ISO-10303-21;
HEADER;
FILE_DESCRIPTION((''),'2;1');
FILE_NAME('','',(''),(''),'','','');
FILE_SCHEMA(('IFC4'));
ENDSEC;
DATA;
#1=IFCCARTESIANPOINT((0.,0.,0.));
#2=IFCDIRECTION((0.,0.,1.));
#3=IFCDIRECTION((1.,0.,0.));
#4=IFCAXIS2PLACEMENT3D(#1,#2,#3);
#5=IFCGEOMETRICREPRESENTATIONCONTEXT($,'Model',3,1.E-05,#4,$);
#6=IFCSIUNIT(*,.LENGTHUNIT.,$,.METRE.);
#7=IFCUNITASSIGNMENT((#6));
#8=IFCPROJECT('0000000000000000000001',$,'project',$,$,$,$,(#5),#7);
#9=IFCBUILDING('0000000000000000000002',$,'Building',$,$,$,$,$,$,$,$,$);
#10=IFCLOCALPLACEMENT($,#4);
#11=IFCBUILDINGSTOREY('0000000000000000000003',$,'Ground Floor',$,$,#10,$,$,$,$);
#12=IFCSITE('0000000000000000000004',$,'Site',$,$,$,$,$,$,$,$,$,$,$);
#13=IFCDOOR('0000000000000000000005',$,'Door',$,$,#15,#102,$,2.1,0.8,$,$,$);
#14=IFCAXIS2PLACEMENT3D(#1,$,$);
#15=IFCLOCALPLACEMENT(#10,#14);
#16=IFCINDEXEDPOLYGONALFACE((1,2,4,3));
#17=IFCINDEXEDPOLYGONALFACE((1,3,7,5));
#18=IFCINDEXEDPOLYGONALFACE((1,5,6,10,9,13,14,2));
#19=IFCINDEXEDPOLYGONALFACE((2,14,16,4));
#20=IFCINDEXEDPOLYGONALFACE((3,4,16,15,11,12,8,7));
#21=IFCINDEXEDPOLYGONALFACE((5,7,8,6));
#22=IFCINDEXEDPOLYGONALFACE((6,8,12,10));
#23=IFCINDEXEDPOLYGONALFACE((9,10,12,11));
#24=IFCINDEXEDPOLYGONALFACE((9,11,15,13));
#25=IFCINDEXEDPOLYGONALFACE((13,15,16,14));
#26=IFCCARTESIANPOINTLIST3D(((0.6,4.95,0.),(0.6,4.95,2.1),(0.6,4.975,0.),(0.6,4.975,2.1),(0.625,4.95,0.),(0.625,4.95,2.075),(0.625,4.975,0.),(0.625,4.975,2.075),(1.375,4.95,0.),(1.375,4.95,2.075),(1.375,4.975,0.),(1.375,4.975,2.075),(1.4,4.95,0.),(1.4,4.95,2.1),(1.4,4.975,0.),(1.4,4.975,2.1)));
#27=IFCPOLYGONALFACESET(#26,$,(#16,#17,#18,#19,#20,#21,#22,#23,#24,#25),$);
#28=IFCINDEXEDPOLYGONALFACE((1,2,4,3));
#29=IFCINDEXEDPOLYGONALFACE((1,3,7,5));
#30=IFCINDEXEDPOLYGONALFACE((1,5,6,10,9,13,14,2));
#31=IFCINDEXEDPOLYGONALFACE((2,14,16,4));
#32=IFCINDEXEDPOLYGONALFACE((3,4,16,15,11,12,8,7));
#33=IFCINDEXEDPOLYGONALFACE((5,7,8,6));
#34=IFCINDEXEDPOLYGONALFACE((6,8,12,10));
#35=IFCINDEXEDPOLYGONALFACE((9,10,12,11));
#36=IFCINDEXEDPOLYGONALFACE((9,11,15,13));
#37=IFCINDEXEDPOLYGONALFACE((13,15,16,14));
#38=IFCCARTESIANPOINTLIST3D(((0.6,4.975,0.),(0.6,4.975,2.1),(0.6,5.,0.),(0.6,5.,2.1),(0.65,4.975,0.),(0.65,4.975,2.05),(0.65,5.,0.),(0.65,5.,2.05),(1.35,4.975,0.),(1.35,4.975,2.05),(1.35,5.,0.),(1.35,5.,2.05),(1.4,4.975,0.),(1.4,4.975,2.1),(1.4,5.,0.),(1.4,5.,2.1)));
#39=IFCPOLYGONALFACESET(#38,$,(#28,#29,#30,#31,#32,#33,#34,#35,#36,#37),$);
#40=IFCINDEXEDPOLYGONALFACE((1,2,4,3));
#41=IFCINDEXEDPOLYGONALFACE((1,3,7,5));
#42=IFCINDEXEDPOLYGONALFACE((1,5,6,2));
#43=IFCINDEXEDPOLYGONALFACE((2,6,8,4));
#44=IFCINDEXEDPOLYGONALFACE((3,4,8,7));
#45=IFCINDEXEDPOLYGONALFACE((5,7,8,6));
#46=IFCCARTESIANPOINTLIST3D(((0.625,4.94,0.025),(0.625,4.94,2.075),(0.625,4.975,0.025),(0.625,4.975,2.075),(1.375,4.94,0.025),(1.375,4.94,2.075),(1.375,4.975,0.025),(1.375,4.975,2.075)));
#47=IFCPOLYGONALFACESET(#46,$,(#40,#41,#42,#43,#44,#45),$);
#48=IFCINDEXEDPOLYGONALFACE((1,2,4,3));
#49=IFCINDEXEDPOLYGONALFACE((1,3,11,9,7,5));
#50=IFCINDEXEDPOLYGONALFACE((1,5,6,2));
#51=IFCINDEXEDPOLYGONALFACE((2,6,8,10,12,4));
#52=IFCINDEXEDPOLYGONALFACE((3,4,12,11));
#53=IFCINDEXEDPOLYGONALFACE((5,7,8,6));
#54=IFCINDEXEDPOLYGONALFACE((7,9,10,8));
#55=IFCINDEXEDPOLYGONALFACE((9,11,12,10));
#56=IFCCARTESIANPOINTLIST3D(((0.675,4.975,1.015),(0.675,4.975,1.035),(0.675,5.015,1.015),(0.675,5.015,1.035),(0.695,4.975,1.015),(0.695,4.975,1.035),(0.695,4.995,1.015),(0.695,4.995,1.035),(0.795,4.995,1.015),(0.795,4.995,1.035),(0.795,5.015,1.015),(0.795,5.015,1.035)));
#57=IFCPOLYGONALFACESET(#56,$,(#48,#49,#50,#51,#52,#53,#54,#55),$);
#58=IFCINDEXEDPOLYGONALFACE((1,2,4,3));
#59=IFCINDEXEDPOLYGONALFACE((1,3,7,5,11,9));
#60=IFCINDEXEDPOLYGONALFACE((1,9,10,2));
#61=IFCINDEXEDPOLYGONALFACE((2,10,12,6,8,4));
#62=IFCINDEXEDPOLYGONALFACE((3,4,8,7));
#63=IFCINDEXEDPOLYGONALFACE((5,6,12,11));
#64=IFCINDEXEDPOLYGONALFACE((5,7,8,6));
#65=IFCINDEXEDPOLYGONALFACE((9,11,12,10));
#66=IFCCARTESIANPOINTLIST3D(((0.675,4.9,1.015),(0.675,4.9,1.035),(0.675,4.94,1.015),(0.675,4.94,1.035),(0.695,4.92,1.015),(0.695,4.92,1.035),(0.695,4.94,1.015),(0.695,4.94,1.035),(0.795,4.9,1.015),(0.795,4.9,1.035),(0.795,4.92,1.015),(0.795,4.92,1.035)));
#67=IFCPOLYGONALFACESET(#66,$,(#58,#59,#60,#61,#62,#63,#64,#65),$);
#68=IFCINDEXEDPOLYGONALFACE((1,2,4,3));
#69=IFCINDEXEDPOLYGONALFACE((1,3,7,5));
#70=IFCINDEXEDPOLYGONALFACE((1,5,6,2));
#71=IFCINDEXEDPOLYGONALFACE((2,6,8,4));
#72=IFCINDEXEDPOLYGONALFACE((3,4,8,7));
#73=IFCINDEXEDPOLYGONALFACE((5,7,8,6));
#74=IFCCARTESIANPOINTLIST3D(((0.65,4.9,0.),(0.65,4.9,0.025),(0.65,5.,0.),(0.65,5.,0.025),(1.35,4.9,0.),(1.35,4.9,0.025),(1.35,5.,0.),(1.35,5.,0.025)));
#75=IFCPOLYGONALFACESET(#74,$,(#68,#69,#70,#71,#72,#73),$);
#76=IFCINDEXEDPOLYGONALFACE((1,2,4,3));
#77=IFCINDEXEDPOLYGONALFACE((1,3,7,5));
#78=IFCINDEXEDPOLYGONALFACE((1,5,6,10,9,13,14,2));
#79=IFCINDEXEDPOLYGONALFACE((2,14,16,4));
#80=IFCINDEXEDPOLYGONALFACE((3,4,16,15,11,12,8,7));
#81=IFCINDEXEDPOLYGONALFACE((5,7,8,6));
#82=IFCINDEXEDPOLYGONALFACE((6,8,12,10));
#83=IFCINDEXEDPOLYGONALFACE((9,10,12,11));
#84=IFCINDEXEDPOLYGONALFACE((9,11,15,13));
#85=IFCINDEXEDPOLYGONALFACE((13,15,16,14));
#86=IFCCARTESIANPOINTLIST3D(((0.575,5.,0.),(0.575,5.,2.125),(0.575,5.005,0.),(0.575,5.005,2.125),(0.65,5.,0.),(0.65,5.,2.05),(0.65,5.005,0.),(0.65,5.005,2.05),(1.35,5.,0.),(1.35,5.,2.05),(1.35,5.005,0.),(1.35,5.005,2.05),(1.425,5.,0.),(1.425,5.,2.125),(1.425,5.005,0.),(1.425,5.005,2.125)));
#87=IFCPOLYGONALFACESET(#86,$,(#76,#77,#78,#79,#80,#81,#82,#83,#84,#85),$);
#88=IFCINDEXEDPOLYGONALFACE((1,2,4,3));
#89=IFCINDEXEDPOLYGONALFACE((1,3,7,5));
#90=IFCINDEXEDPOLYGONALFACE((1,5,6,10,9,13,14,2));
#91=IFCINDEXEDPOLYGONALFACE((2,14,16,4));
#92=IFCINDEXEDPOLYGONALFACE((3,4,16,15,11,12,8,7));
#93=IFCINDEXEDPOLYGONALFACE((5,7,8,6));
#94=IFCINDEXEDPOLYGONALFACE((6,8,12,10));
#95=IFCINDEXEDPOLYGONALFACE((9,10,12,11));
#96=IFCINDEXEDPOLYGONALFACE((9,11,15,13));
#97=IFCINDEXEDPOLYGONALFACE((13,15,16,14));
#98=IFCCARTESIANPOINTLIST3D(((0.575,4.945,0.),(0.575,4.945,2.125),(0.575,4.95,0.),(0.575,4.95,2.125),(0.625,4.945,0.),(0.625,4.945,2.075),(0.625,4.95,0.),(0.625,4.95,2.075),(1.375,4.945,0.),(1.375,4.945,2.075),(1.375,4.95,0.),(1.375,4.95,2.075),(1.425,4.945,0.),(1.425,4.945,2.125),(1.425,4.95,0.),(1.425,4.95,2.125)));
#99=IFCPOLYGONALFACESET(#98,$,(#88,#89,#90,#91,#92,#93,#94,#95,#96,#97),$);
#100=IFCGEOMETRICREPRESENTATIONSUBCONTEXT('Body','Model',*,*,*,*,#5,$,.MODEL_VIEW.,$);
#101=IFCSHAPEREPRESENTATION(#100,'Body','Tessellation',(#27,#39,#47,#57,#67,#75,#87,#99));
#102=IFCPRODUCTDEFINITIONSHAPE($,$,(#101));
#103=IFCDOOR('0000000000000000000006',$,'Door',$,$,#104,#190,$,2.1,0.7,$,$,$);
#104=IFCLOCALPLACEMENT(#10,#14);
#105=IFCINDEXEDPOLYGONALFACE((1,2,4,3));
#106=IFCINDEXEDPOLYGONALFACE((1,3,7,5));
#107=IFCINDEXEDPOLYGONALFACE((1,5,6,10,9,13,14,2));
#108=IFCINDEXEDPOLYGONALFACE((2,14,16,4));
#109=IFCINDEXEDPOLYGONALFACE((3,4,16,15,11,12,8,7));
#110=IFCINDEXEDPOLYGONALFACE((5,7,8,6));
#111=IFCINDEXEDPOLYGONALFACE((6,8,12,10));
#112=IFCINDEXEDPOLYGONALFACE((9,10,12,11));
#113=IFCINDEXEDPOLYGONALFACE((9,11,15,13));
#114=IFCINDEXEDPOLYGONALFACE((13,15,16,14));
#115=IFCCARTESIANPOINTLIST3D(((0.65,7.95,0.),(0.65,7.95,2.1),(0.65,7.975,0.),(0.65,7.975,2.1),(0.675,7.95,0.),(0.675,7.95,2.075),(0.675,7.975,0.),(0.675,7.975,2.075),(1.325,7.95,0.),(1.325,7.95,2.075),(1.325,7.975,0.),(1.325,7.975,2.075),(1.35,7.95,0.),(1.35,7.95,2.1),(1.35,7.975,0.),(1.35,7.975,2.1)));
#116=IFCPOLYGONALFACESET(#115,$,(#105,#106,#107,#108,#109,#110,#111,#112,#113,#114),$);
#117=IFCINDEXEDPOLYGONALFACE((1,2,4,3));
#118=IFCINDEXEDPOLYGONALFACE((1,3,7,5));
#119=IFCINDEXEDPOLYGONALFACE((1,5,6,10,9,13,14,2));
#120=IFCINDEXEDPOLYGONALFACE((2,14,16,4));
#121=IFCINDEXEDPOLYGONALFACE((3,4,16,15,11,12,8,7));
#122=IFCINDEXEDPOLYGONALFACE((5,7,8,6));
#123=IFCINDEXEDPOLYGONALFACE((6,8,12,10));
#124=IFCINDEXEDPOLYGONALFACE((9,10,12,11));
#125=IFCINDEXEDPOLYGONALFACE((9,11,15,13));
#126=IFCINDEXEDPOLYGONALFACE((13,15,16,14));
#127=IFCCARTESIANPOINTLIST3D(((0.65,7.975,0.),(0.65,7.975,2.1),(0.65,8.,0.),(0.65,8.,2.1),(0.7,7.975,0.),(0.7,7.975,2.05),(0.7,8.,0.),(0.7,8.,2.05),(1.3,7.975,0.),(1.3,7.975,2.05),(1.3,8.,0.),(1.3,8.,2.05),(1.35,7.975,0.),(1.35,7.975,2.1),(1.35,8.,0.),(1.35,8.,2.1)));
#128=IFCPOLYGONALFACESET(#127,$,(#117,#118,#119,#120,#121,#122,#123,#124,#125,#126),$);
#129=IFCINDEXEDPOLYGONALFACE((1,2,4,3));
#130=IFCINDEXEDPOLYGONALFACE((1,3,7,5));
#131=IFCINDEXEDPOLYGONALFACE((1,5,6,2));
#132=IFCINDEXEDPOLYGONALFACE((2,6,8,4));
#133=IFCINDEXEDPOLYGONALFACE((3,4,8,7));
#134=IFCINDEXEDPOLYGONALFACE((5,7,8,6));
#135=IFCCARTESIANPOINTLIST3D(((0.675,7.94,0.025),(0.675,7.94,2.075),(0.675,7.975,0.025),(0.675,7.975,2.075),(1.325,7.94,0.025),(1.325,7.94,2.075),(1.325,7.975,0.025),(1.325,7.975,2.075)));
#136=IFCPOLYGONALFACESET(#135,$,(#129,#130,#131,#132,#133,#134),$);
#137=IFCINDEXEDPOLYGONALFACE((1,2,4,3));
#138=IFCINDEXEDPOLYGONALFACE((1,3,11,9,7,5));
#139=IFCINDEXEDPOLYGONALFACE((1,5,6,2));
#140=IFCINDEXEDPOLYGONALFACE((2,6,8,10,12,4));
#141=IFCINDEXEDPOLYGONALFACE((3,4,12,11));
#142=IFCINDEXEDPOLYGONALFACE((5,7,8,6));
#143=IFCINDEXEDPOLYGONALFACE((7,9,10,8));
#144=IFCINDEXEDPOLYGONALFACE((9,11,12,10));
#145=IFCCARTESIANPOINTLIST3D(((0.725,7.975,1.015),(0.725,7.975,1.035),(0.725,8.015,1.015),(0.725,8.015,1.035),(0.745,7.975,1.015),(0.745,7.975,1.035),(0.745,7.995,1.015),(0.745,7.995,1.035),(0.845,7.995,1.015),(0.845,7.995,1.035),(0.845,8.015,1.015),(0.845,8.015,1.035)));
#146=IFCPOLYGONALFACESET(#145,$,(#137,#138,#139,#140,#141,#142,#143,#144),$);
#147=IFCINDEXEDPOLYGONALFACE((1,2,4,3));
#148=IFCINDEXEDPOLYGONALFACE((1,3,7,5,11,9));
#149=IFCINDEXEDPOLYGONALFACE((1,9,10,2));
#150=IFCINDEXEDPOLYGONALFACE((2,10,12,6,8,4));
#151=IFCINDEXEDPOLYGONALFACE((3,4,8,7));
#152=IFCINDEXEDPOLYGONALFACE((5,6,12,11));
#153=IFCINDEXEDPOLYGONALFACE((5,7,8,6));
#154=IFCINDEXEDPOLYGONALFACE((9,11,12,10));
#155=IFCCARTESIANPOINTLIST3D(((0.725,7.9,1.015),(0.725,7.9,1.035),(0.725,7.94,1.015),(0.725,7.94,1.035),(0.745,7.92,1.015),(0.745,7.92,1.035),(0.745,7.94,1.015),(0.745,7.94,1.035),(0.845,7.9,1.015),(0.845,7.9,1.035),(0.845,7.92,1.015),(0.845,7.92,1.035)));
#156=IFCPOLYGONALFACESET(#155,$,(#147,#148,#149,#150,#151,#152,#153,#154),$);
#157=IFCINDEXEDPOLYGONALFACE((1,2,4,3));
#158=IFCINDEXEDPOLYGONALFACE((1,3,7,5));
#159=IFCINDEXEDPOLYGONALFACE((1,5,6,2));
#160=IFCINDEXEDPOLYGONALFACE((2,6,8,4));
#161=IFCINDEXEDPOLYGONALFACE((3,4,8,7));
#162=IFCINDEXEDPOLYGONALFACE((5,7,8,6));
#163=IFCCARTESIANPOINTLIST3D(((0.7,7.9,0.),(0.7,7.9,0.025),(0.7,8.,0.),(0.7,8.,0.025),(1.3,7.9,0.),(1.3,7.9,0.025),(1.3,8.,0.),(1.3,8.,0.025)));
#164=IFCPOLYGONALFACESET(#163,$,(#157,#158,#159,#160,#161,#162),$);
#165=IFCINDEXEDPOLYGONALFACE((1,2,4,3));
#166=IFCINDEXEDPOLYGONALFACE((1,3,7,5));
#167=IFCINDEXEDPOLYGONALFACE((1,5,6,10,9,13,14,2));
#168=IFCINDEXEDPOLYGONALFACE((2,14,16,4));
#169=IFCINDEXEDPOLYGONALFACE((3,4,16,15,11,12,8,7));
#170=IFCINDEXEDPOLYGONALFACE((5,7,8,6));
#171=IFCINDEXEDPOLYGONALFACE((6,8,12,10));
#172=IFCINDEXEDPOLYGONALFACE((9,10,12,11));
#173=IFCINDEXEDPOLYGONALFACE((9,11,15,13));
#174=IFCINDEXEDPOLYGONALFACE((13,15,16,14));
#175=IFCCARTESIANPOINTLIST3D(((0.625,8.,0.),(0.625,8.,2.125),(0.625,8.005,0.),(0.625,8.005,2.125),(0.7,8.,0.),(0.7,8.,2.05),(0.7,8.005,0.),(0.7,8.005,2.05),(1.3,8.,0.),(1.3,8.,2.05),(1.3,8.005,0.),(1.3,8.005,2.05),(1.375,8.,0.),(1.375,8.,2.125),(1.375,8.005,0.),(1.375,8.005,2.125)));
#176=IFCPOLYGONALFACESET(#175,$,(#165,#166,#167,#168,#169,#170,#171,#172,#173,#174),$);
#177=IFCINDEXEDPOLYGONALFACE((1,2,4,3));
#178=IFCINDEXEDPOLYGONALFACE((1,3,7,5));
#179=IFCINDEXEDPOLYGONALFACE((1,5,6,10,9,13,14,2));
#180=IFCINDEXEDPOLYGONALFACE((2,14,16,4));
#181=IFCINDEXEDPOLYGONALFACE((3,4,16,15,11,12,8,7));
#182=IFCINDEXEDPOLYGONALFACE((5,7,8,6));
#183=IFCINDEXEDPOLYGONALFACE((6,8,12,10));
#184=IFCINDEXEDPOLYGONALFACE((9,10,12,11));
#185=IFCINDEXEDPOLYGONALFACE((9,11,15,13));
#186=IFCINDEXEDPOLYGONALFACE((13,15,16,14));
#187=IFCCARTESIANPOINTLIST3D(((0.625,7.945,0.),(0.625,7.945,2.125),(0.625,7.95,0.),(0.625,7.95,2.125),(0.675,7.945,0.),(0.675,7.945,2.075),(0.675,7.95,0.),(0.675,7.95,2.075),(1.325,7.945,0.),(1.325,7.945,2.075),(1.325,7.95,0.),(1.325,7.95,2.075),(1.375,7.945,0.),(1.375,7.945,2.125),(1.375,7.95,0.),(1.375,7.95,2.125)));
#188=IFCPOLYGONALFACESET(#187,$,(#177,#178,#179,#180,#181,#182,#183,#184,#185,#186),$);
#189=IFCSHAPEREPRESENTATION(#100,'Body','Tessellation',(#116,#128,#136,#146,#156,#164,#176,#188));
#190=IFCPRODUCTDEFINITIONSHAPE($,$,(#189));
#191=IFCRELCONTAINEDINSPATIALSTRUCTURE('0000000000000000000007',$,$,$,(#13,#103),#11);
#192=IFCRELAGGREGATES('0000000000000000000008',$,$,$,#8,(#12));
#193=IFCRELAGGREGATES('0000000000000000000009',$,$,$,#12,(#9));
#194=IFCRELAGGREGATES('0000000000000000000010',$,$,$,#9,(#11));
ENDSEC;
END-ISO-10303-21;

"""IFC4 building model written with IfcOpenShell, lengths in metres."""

from ifc_helpers import new_model, si_unit, frame, origin_with_axes, place, context, subcontext, project, spatial, line, indexed_curve, outline, extrude, element, save


model = new_model("IFC4")

# Units and contexts
model_context = context("Model", 3, precision=1e-05, world=origin_with_axes())
body_context = subcontext(model_context, "Body", "Model", "MODEL_VIEW")
ifc_project = project(units=[si_unit("LENGTHUNIT", "METRE")], contexts=[model_context])

# Site, building, storey
site = spatial("IfcSite", under=ifc_project, Name="Site")
building = spatial("IfcBuilding", under=site, Name="Building")
storey_placement = place(None, origin_with_axes())
storey = spatial("IfcBuildingStorey", under=building, at=storey_placement, Name="Ground Floor")

# Doors
door_1_placement = place(storey_placement, frame((1.4, 5.0, 0.0), z_axis=(0.0, 0.0, 1.0), x_axis=(-1.0, 0.0, 0.0)))
element("IfcDoor", 1, at=door_1_placement, inside=storey, Name="Door", OverallHeight=2.1, OverallWidth=0.8, context=body_context, shape_type="SweptSolid", body=[
    extrude(outline(indexed_curve([(0.0, 0.0), (0.0, 2.1), (0.8, 2.1), (0.8, 0.0), (0.775, 0.0), (0.775, 2.075), (0.025, 2.075), (0.025, 0.0)], segments=[line(1, 2, 3, 4, 5, 6, 7, 8, 1)])), frame((0.0, 0.025, 0.0), z_axis=(0.0, -1.0, 0.0), x_axis=(1.0, 0.0, 0.0)), (0.0, 0.0, -1.0), 0.025),
    extrude(outline(indexed_curve([(0.0, 0.0), (0.0, 2.1), (0.8, 2.1), (0.8, 0.0), (0.75, 0.0), (0.75, 2.05), (0.05, 2.05), (0.05, 0.0)], segments=[line(1, 2, 3, 4, 5, 6, 7, 8, 1)])), frame((0.0, 0.0, 0.0), z_axis=(0.0, -1.0, 0.0), x_axis=(1.0, 0.0, 0.0)), (0.0, 0.0, -1.0), 0.025),
    extrude(outline(indexed_curve([(0.0, 0.0), (0.75, 0.0), (0.75, 0.035), (0.0, 0.035)], segments=[line(1, 2, 3, 4, 1)])), frame((0.025, 0.025, 0.025), z_axis=(0.0, 0.0, 1.0), x_axis=(1.0, 0.0, 0.0)), (0.0, 0.0, 1.0), 2.05),
    extrude(outline(indexed_curve([(0.0, 0.0), (0.0, -0.04), (-0.12, -0.04), (-0.12, -0.02), (-0.02, -0.02), (-0.02, 0.0)], segments=[line(1, 2, 3, 4, 5, 6, 1)])), frame((0.725, 0.025, 1.015), z_axis=(0.0, 0.0, 1.0), x_axis=(1.0, 0.0, 0.0)), (0.0, 0.0, 1.0), 0.02),
    extrude(outline(indexed_curve([(0.0, 0.0), (0.0, 0.04), (-0.12, 0.04), (-0.12, 0.02), (-0.02, 0.02), (-0.02, 0.0)], segments=[line(1, 2, 3, 4, 5, 6, 1)])), frame((0.725, 0.06, 1.015), z_axis=(0.0, 0.0, 1.0), x_axis=(1.0, 0.0, 0.0)), (0.0, 0.0, 1.0), 0.02),
    extrude(outline(indexed_curve([(0.0, 0.0), (0.7, 0.0), (0.7, 0.1), (0.0, 0.1)], segments=[line(1, 2, 3, 4, 1)])), frame((0.05, 0.0, 0.0), z_axis=(0.0, 0.0, 1.0), x_axis=(1.0, 0.0, 0.0)), (0.0, 0.0, 1.0), 0.025),
    extrude(outline(indexed_curve([(0.0, 0.0), (0.0, 2.125), (0.85, 2.125), (0.85, 0.0), (0.775, 0.0), (0.775, 2.05), (0.075, 2.05), (0.075, 0.0)], segments=[line(1, 2, 3, 4, 5, 6, 7, 8, 1)])), frame((-0.025, -0.005, 0.0), z_axis=(0.0, -1.0, 0.0), x_axis=(1.0, 0.0, 0.0)), (0.0, 0.0, -1.0), 0.005),
    extrude(outline(indexed_curve([(0.0, 0.0), (0.0, 2.125), (0.85, 2.125), (0.85, 0.0), (0.8, 0.0), (0.8, 2.075), (0.05, 2.075), (0.05, 0.0)], segments=[line(1, 2, 3, 4, 5, 6, 7, 8, 1)])), frame((-0.025, 0.05, 0.0), z_axis=(0.0, -1.0, 0.0), x_axis=(1.0, 0.0, 0.0)), (0.0, 0.0, -1.0), 0.005),
])
door_2_placement = place(storey_placement, frame((1.35, 8.0, 0.0), z_axis=(0.0, 0.0, 1.0), x_axis=(-1.0, 0.0, 0.0)))
element("IfcDoor", 2, at=door_2_placement, inside=storey, Name="Door", OverallHeight=2.1, OverallWidth=0.7, context=body_context, shape_type="SweptSolid", body=[
    extrude(outline(indexed_curve([(0.0, 0.0), (0.0, 2.1), (0.7, 2.1), (0.7, 0.0), (0.675, 0.0), (0.675, 2.075), (0.025, 2.075), (0.025, 0.0)], segments=[line(1, 2, 3, 4, 5, 6, 7, 8, 1)])), frame((0.0, 0.025, 0.0), z_axis=(0.0, -1.0, 0.0), x_axis=(1.0, 0.0, 0.0)), (0.0, 0.0, -1.0), 0.025),
    extrude(outline(indexed_curve([(0.0, 0.0), (0.0, 2.1), (0.7, 2.1), (0.7, 0.0), (0.65, 0.0), (0.65, 2.05), (0.05, 2.05), (0.05, 0.0)], segments=[line(1, 2, 3, 4, 5, 6, 7, 8, 1)])), frame((0.0, 0.0, 0.0), z_axis=(0.0, -1.0, 0.0), x_axis=(1.0, 0.0, 0.0)), (0.0, 0.0, -1.0), 0.025),
    extrude(outline(indexed_curve([(0.0, 0.0), (0.65, 0.0), (0.65, 0.035), (0.0, 0.035)], segments=[line(1, 2, 3, 4, 1)])), frame((0.025, 0.025, 0.025), z_axis=(0.0, 0.0, 1.0), x_axis=(1.0, 0.0, 0.0)), (0.0, 0.0, 1.0), 2.05),
    extrude(outline(indexed_curve([(0.0, 0.0), (0.0, -0.04), (-0.12, -0.04), (-0.12, -0.02), (-0.02, -0.02), (-0.02, 0.0)], segments=[line(1, 2, 3, 4, 5, 6, 1)])), frame((0.625, 0.025, 1.015), z_axis=(0.0, 0.0, 1.0), x_axis=(1.0, 0.0, 0.0)), (0.0, 0.0, 1.0), 0.02),
    extrude(outline(indexed_curve([(0.0, 0.0), (0.0, 0.04), (-0.12, 0.04), (-0.12, 0.02), (-0.02, 0.02), (-0.02, 0.0)], segments=[line(1, 2, 3, 4, 5, 6, 1)])), frame((0.625, 0.06, 1.015), z_axis=(0.0, 0.0, 1.0), x_axis=(1.0, 0.0, 0.0)), (0.0, 0.0, 1.0), 0.02),
    extrude(outline(indexed_curve([(0.0, 0.0), (0.6, 0.0), (0.6, 0.1), (0.0, 0.1)], segments=[line(1, 2, 3, 4, 1)])), frame((0.05, 0.0, 0.0), z_axis=(0.0, 0.0, 1.0), x_axis=(1.0, 0.0, 0.0)), (0.0, 0.0, 1.0), 0.025),
    extrude(outline(indexed_curve([(0.0, 0.0), (0.0, 2.125), (0.75, 2.125), (0.75, 0.0), (0.675, 0.0), (0.675, 2.05), (0.075, 2.05), (0.075, 0.0)], segments=[line(1, 2, 3, 4, 5, 6, 7, 8, 1)])), frame((-0.025, -0.005, 0.0), z_axis=(0.0, -1.0, 0.0), x_axis=(1.0, 0.0, 0.0)), (0.0, 0.0, -1.0), 0.005),
    extrude(outline(indexed_curve([(0.0, 0.0), (0.0, 2.125), (0.75, 2.125), (0.75, 0.0), (0.7, 0.0), (0.7, 2.075), (0.05, 2.075), (0.05, 0.0)], segments=[line(1, 2, 3, 4, 5, 6, 7, 8, 1)])), frame((-0.025, 0.05, 0.0), z_axis=(0.0, -1.0, 0.0), x_axis=(1.0, 0.0, 0.0)), (0.0, 0.0, -1.0), 0.005),
])

save(model, "model.ifc")
